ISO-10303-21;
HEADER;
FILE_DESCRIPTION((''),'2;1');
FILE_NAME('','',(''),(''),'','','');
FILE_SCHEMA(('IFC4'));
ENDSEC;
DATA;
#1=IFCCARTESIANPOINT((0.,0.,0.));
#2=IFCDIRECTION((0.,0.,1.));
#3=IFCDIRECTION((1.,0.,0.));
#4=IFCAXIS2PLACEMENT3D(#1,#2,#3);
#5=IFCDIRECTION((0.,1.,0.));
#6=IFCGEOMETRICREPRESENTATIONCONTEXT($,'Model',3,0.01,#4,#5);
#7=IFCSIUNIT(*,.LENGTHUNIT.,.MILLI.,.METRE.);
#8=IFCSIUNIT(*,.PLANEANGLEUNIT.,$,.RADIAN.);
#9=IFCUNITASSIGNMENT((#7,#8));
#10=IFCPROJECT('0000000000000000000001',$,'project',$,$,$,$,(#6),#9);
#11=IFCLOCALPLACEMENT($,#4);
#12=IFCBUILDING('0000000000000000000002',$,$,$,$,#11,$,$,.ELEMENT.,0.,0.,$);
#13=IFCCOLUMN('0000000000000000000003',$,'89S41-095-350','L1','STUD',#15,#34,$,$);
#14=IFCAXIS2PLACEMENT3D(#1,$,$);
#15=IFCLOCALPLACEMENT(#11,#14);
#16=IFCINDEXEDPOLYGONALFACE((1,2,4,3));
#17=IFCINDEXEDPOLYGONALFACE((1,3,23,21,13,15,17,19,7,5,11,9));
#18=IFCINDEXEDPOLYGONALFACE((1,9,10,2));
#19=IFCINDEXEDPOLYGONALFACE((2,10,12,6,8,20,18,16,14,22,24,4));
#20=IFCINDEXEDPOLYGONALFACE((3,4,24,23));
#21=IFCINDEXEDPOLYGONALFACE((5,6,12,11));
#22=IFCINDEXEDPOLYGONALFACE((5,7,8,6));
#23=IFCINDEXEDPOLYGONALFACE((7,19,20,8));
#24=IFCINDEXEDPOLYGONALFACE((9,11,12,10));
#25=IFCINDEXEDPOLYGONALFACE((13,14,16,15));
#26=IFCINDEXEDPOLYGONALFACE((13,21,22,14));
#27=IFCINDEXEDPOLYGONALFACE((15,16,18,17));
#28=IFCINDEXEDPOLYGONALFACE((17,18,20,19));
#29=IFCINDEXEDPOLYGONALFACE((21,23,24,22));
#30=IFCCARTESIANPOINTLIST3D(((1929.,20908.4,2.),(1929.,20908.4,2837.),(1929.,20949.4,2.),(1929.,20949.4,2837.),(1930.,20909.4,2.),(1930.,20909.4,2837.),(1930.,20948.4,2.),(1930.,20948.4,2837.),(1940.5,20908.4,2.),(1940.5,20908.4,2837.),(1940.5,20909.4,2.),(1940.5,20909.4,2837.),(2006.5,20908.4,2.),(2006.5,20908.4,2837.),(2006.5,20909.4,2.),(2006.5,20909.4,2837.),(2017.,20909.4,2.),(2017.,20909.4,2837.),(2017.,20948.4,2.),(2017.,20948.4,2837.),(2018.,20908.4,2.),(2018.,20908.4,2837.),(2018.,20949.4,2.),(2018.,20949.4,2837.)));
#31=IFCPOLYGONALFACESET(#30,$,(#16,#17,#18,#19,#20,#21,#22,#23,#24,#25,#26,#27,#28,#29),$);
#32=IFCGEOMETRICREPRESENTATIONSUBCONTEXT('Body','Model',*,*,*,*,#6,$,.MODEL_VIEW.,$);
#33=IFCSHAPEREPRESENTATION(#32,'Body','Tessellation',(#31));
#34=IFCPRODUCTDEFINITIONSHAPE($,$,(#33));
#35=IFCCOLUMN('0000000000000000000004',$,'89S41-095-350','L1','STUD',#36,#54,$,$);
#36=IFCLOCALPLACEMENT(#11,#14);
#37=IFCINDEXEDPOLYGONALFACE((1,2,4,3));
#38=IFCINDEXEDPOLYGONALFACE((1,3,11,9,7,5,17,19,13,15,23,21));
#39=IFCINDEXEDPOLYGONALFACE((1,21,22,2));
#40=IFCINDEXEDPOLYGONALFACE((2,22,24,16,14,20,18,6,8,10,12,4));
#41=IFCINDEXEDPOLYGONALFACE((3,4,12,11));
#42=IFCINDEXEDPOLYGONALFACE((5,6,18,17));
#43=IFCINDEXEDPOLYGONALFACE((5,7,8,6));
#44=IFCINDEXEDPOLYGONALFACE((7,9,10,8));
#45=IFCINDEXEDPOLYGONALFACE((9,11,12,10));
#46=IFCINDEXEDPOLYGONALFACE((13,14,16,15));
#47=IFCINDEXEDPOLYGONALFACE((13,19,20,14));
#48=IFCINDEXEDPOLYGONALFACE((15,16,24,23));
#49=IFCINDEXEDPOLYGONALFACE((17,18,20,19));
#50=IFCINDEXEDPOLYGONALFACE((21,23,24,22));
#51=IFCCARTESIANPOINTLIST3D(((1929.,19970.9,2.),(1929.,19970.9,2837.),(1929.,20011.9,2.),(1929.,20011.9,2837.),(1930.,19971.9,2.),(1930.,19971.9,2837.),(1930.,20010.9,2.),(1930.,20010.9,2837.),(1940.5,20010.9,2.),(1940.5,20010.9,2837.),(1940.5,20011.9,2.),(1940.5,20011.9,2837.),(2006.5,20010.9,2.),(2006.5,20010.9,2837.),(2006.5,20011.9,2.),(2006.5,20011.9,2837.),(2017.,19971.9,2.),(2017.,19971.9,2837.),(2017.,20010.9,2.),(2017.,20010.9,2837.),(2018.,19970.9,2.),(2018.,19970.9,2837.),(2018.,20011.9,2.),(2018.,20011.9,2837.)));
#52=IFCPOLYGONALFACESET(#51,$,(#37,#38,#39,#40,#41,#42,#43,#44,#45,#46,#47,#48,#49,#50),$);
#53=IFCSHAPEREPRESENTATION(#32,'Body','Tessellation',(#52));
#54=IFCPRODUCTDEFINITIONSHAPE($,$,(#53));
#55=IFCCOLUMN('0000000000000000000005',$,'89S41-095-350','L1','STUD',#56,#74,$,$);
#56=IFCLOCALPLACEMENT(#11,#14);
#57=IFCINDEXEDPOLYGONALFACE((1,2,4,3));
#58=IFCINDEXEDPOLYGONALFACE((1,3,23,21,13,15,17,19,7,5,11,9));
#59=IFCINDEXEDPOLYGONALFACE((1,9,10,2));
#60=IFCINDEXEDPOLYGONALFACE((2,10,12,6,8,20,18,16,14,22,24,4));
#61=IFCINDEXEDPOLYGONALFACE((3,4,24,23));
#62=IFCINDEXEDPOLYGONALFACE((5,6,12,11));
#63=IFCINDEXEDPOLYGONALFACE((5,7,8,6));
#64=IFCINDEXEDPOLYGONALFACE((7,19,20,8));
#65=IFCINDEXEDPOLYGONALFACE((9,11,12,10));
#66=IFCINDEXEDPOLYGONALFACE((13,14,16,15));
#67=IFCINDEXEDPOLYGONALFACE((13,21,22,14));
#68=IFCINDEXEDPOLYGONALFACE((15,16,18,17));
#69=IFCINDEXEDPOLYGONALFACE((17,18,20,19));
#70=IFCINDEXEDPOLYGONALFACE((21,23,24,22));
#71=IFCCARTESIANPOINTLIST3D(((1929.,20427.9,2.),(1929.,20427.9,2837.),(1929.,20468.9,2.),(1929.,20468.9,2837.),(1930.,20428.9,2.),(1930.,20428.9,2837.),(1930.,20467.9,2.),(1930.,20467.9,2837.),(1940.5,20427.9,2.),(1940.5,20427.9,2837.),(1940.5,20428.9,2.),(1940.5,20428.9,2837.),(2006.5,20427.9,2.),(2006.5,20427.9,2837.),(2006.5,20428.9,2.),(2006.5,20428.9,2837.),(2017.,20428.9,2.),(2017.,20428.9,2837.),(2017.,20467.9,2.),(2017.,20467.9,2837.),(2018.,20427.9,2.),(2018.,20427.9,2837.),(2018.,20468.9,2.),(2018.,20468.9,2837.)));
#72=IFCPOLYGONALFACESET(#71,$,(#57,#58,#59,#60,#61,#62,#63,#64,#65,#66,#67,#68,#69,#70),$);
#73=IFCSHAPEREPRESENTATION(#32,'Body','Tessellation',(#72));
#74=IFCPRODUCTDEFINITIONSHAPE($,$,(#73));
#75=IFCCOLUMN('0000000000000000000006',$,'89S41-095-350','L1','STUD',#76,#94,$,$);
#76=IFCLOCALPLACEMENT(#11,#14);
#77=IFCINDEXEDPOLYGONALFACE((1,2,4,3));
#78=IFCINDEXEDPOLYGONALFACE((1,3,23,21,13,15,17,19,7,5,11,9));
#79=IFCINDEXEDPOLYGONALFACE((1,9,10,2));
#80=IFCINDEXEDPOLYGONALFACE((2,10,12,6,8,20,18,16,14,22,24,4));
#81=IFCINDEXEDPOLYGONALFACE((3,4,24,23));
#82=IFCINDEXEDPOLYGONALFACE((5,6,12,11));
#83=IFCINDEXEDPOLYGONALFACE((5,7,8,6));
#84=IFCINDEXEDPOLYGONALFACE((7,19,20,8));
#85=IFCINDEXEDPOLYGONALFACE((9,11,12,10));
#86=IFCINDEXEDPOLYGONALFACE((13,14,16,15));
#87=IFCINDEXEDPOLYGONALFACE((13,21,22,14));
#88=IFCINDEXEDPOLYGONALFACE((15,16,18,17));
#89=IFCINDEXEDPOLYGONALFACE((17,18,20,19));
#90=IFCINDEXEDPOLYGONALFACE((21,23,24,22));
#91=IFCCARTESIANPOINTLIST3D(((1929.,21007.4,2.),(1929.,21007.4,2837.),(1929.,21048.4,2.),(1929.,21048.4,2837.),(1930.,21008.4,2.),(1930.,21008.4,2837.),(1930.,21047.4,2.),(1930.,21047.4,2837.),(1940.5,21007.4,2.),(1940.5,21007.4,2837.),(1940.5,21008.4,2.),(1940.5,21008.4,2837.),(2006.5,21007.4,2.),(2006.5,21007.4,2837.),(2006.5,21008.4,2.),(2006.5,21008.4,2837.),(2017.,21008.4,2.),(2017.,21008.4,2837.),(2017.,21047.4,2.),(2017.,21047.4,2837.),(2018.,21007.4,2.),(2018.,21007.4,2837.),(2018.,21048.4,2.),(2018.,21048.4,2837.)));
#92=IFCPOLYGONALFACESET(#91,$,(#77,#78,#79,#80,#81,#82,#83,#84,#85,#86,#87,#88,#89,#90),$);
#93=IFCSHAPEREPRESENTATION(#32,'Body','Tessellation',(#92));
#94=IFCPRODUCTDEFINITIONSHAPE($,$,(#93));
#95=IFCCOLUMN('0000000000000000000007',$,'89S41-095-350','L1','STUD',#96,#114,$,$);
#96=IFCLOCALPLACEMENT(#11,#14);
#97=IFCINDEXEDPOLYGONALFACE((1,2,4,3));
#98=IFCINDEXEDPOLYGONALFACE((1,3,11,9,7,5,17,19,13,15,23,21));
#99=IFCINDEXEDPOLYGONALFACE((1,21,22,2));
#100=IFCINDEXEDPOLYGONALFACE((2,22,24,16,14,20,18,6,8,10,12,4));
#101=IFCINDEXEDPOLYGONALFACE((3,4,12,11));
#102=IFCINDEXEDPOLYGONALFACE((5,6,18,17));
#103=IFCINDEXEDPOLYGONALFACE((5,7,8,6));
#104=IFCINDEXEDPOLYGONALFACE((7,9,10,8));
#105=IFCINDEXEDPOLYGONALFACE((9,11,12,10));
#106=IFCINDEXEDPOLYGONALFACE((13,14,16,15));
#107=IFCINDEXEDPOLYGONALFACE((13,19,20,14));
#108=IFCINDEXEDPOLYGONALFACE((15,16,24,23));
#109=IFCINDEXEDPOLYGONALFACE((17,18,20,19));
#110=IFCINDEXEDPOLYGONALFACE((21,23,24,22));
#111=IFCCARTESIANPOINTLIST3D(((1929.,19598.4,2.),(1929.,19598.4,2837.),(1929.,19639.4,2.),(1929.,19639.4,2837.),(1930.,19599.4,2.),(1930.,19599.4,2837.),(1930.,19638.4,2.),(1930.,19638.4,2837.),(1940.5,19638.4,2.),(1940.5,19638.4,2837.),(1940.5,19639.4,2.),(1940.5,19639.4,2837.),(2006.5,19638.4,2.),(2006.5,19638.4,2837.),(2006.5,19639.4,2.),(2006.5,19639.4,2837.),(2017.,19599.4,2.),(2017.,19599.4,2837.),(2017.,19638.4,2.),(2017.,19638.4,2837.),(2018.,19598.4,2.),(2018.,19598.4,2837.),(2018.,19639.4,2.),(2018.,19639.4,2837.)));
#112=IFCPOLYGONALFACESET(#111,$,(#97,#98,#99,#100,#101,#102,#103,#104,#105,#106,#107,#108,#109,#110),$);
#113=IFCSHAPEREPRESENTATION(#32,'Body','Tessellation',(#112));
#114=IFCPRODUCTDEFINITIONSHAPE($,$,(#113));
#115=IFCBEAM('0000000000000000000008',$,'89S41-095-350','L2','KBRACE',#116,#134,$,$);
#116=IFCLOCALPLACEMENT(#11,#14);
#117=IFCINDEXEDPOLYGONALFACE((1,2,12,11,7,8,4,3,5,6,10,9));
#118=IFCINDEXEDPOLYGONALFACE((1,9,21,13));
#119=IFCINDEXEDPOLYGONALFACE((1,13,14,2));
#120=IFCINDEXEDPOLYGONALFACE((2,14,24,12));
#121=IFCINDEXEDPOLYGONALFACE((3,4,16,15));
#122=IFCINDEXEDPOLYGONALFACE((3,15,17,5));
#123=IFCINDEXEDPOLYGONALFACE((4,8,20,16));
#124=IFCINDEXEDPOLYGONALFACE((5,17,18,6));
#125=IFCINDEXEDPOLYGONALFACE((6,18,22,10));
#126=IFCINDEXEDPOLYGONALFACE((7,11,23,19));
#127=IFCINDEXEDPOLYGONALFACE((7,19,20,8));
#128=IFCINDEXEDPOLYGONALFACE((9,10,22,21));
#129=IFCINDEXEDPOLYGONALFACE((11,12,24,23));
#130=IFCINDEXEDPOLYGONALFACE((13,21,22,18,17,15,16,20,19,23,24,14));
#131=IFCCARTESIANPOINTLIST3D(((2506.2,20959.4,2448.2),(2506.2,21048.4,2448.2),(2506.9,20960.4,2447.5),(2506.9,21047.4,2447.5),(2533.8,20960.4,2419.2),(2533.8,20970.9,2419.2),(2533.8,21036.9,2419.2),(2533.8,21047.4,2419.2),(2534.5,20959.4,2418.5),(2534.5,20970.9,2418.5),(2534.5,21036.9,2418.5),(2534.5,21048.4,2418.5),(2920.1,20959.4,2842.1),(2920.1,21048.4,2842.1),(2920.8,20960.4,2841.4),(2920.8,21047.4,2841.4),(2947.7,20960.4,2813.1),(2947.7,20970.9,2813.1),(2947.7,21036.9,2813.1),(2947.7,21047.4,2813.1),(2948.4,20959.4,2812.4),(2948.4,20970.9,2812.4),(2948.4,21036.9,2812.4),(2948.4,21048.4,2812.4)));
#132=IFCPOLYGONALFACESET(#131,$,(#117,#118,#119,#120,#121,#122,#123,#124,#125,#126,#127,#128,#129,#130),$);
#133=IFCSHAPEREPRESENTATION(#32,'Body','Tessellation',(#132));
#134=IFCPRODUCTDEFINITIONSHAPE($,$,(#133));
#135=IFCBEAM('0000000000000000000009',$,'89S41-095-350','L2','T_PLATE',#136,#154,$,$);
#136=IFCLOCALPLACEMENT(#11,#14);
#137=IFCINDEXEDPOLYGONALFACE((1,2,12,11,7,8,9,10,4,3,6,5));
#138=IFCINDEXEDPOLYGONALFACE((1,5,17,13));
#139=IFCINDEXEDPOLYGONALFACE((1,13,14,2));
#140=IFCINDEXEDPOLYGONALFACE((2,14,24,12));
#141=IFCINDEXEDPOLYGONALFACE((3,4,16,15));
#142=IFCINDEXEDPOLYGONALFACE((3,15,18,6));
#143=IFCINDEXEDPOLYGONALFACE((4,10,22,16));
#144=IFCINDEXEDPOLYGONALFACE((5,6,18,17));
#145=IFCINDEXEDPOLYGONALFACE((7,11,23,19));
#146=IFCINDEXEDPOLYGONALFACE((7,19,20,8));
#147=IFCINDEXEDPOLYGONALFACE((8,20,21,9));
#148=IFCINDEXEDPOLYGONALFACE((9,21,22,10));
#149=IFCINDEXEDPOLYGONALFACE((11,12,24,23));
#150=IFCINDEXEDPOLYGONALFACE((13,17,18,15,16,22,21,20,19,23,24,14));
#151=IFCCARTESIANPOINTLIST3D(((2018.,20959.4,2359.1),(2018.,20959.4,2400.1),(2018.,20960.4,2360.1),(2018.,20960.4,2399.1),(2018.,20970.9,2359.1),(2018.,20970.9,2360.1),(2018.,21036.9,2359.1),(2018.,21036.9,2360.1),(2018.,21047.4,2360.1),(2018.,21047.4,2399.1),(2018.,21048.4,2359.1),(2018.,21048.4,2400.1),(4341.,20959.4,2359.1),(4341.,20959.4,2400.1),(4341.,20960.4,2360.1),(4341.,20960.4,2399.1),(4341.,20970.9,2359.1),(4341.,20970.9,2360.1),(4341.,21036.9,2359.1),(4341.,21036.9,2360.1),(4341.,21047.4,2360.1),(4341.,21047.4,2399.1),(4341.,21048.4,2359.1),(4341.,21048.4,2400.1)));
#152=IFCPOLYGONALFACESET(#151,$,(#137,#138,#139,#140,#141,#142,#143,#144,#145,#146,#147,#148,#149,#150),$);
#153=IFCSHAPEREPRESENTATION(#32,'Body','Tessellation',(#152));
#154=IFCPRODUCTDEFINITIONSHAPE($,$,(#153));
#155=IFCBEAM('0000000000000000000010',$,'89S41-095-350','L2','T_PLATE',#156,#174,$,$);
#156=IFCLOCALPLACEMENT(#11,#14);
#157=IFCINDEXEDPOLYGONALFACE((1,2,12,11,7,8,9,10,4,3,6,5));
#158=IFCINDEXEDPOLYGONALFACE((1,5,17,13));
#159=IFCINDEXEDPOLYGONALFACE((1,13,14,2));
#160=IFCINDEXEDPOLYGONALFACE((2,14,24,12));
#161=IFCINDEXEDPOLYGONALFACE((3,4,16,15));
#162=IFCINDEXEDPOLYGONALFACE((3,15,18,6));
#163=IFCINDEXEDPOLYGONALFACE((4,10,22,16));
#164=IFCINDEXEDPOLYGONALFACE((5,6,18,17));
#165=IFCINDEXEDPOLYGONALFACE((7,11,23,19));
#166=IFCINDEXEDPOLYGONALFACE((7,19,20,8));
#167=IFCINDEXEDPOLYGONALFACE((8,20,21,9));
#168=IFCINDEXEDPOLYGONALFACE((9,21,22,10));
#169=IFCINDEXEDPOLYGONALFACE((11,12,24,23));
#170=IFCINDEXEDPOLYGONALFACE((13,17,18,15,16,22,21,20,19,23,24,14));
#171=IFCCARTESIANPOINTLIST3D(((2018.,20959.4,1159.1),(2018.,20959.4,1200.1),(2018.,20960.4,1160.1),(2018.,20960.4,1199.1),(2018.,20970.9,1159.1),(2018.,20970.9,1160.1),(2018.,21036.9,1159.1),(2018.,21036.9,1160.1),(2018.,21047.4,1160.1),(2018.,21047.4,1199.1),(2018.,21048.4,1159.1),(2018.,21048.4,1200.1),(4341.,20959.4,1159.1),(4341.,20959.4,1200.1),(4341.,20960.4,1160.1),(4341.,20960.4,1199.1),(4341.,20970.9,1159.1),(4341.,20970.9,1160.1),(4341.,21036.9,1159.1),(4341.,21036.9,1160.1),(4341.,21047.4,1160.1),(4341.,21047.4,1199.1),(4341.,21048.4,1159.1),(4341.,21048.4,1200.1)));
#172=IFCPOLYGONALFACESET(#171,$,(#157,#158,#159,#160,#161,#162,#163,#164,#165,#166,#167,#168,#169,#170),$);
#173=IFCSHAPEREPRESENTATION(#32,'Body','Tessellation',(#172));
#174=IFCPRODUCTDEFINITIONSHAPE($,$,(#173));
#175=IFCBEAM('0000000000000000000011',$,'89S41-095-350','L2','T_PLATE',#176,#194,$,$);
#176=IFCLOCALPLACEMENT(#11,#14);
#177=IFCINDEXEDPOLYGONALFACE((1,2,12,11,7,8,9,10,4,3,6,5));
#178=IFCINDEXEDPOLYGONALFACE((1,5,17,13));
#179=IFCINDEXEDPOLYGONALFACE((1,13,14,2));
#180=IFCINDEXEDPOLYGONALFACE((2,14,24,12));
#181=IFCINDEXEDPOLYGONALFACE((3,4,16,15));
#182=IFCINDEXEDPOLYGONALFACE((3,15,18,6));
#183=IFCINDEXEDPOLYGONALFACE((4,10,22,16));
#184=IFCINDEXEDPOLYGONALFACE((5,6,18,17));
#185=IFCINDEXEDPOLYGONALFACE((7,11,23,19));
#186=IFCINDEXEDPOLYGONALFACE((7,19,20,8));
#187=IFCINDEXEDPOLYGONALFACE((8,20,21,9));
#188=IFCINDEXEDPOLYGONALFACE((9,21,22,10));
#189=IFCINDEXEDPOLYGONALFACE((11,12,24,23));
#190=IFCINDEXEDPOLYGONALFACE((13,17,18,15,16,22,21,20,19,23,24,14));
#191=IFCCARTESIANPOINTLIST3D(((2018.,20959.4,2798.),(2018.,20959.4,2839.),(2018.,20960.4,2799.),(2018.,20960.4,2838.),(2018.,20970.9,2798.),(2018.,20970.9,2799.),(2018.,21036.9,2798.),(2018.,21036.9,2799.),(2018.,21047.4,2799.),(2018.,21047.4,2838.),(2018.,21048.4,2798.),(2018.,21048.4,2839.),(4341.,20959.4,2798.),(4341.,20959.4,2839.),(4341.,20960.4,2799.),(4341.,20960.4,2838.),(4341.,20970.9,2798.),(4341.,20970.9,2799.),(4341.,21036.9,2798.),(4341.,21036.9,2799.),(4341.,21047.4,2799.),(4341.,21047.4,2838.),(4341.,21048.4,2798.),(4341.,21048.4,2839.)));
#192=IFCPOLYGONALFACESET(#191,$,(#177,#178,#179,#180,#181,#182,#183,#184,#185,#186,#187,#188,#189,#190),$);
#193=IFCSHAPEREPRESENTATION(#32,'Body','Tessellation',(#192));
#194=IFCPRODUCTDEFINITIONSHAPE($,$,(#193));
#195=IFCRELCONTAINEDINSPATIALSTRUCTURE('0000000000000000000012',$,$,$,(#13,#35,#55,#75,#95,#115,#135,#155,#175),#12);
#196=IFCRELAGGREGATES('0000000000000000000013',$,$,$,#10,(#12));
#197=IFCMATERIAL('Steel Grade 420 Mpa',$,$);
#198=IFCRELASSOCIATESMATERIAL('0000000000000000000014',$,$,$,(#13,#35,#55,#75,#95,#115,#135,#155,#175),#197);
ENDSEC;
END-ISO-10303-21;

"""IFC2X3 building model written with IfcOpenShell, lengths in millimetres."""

from ifc_helpers import new_model, si_unit, direction, frame, origin, origin_with_axes, origin_2d_with_axis, place, context, subcontext, project, spatial, c_section, extrude, source, transform, mapped, material, element, save


model = new_model("IFC2X3")

# Units and contexts
model_context = context("Model", 3, precision=0.01, world=origin_with_axes(), true_north=direction((0.0, 1.0, 0.0)))
body_context = subcontext(model_context, "Body", "Model", "MODEL_VIEW")
ifc_project = project(units=[si_unit("LENGTHUNIT", "METRE", prefix="MILLI"), si_unit("PLANEANGLEUNIT", "RADIAN")], contexts=[model_context])

# Building
building_placement = place(None, origin_with_axes())
building = spatial("IfcBuilding", under=ifc_project, at=building_placement, CompositionType="ELEMENT", ElevationOfRefHeight=0.0, ElevationOfTerrain=0.0)

# Columns
ifc_material = material(Name="Steel Grade 420 Mpa")
shared_shape_1 = source(origin(), body_context, "Body", "SweptSolid", [
    extrude(c_section(Depth=89.0, Width=41.0, WallThickness=1.0, Girth=11.5, at=origin_2d_with_axis()), origin_with_axes(), (0.0, 0.0, 1.0), 2835.0),
])
column_1_placement = place(None, frame((1973.5, 20928.9, 2.0), z_axis=(0.0, 0.0, 1.0), x_axis=(0.0, -1.0, 0.0)))
element("IfcColumn", 1, at=column_1_placement, inside=building, material=ifc_material, Name="89S41-095-350", Description="L1", ObjectType="STUD", context=body_context, shape_type="MappedRepresentation", body=[
    mapped(shared_shape_1, transform((0.0, 0.0, 0.0), scale=1.0)),
])
shared_shape_2 = source(origin(), body_context, "Body", "SweptSolid", [
    extrude(c_section(Depth=89.0, Width=41.0, WallThickness=1.0, Girth=11.5, at=origin_2d_with_axis()), origin_with_axes(), (0.0, 0.0, 1.0), 2835.0),
])
column_2_placement = place(None, frame((1973.5, 19991.4, 2.0), z_axis=(0.0, 0.0, 1.0), x_axis=(0.0, 1.0, 0.0)))
element("IfcColumn", 2, at=column_2_placement, inside=building, material=ifc_material, Name="89S41-095-350", Description="L1", ObjectType="STUD", context=body_context, shape_type="MappedRepresentation", body=[
    mapped(shared_shape_2, transform((0.0, 0.0, 0.0), scale=1.0)),
])
shared_shape_3 = source(origin(), body_context, "Body", "SweptSolid", [
    extrude(c_section(Depth=89.0, Width=41.0, WallThickness=1.0, Girth=11.5, at=origin_2d_with_axis()), origin_with_axes(), (0.0, 0.0, 1.0), 2835.0),
])
column_3_placement = place(None, frame((1973.5, 20448.4, 2.0), z_axis=(0.0, 0.0, 1.0), x_axis=(0.0, -1.0, 0.0)))
element("IfcColumn", 3, at=column_3_placement, inside=building, material=ifc_material, Name="89S41-095-350", Description="L1", ObjectType="STUD", context=body_context, shape_type="MappedRepresentation", body=[
    mapped(shared_shape_3, transform((0.0, 0.0, 0.0), scale=1.0)),
])
shared_shape_4 = source(origin(), body_context, "Body", "SweptSolid", [
    extrude(c_section(Depth=89.0, Width=41.0, WallThickness=1.0, Girth=11.5, at=origin_2d_with_axis()), origin_with_axes(), (0.0, 0.0, 1.0), 2835.0),
])
column_4_placement = place(None, frame((1973.5, 21027.9, 2.0), z_axis=(0.0, 0.0, 1.0), x_axis=(0.0, -1.0, 0.0)))
element("IfcColumn", 4, at=column_4_placement, inside=building, material=ifc_material, Name="89S41-095-350", Description="L1", ObjectType="STUD", context=body_context, shape_type="MappedRepresentation", body=[
    mapped(shared_shape_4, transform((0.0, 0.0, 0.0), scale=1.0)),
])
shared_shape_5 = source(origin(), body_context, "Body", "SweptSolid", [
    extrude(c_section(Depth=89.0, Width=41.0, WallThickness=1.0, Girth=11.5, at=origin_2d_with_axis()), origin_with_axes(), (0.0, 0.0, 1.0), 2835.0),
])
column_5_placement = place(None, frame((1973.5, 19618.9, 2.0), z_axis=(0.0, 0.0, 1.0), x_axis=(0.0, 1.0, 0.0)))
element("IfcColumn", 5, at=column_5_placement, inside=building, material=ifc_material, Name="89S41-095-350", Description="L1", ObjectType="STUD", context=body_context, shape_type="MappedRepresentation", body=[
    mapped(shared_shape_5, transform((0.0, 0.0, 0.0), scale=1.0)),
])

# Beams
shared_shape_6 = source(origin(), body_context, "Body", "SweptSolid", [
    extrude(c_section(Depth=89.0, Width=41.0, WallThickness=1.0, Girth=11.5, at=origin_2d_with_axis()), origin_with_axes(), (0.0, 0.0, 1.0), 571.4),
])
beam_1_placement = place(None, frame((2520.3, 21003.9, 2433.3), z_axis=(0.724398, 0.0, 0.689382), x_axis=(0.689382, 0.0, -0.724398)))
element("IfcBeam", 6, at=beam_1_placement, inside=building, material=ifc_material, Name="89S41-095-350", Description="L2", ObjectType="KBRACE", context=body_context, shape_type="MappedRepresentation", body=[
    mapped(shared_shape_6, transform((0.0, 0.0, 0.0), scale=1.0)),
])
shared_shape_7 = source(origin(), body_context, "Body", "SweptSolid", [
    extrude(c_section(Depth=89.0, Width=41.0, WallThickness=1.0, Girth=11.5, at=origin_2d_with_axis()), origin_with_axes(), (0.0, 0.0, 1.0), 2323.0),
])
beam_2_placement = place(None, frame((2018.0, 21003.9, 2379.6), z_axis=(1.0, 0.0, 0.0), x_axis=(0.0, 0.0, -1.0)))
element("IfcBeam", 7, at=beam_2_placement, inside=building, material=ifc_material, Name="89S41-095-350", Description="L2", ObjectType="T_PLATE", context=body_context, shape_type="MappedRepresentation", body=[
    mapped(shared_shape_7, transform((0.0, 0.0, 0.0), scale=1.0)),
])
shared_shape_8 = source(origin(), body_context, "Body", "SweptSolid", [
    extrude(c_section(Depth=89.0, Width=41.0, WallThickness=1.0, Girth=11.5, at=origin_2d_with_axis()), origin_with_axes(), (0.0, 0.0, 1.0), 2323.0),
])
beam_3_placement = place(None, frame((2018.0, 21003.9, 1179.6), z_axis=(1.0, 0.0, 0.0), x_axis=(0.0, 0.0, -1.0)))
element("IfcBeam", 8, at=beam_3_placement, inside=building, material=ifc_material, Name="89S41-095-350", Description="L2", ObjectType="T_PLATE", context=body_context, shape_type="MappedRepresentation", body=[
    mapped(shared_shape_8, transform((0.0, 0.0, 0.0), scale=1.0)),
])
shared_shape_9 = source(origin(), body_context, "Body", "SweptSolid", [
    extrude(c_section(Depth=89.0, Width=41.0, WallThickness=1.0, Girth=11.5, at=origin_2d_with_axis()), origin_with_axes(), (0.0, 0.0, 1.0), 2323.0),
])
beam_4_placement = place(None, frame((2018.0, 21003.9, 2818.5), z_axis=(1.0, 0.0, 0.0), x_axis=(0.0, 0.0, -1.0)))
element("IfcBeam", 9, at=beam_4_placement, inside=building, material=ifc_material, Name="89S41-095-350", Description="L2", ObjectType="T_PLATE", context=body_context, shape_type="MappedRepresentation", body=[
    mapped(shared_shape_9, transform((0.0, 0.0, 0.0), scale=1.0)),
])

save(model, "model.ifc")
